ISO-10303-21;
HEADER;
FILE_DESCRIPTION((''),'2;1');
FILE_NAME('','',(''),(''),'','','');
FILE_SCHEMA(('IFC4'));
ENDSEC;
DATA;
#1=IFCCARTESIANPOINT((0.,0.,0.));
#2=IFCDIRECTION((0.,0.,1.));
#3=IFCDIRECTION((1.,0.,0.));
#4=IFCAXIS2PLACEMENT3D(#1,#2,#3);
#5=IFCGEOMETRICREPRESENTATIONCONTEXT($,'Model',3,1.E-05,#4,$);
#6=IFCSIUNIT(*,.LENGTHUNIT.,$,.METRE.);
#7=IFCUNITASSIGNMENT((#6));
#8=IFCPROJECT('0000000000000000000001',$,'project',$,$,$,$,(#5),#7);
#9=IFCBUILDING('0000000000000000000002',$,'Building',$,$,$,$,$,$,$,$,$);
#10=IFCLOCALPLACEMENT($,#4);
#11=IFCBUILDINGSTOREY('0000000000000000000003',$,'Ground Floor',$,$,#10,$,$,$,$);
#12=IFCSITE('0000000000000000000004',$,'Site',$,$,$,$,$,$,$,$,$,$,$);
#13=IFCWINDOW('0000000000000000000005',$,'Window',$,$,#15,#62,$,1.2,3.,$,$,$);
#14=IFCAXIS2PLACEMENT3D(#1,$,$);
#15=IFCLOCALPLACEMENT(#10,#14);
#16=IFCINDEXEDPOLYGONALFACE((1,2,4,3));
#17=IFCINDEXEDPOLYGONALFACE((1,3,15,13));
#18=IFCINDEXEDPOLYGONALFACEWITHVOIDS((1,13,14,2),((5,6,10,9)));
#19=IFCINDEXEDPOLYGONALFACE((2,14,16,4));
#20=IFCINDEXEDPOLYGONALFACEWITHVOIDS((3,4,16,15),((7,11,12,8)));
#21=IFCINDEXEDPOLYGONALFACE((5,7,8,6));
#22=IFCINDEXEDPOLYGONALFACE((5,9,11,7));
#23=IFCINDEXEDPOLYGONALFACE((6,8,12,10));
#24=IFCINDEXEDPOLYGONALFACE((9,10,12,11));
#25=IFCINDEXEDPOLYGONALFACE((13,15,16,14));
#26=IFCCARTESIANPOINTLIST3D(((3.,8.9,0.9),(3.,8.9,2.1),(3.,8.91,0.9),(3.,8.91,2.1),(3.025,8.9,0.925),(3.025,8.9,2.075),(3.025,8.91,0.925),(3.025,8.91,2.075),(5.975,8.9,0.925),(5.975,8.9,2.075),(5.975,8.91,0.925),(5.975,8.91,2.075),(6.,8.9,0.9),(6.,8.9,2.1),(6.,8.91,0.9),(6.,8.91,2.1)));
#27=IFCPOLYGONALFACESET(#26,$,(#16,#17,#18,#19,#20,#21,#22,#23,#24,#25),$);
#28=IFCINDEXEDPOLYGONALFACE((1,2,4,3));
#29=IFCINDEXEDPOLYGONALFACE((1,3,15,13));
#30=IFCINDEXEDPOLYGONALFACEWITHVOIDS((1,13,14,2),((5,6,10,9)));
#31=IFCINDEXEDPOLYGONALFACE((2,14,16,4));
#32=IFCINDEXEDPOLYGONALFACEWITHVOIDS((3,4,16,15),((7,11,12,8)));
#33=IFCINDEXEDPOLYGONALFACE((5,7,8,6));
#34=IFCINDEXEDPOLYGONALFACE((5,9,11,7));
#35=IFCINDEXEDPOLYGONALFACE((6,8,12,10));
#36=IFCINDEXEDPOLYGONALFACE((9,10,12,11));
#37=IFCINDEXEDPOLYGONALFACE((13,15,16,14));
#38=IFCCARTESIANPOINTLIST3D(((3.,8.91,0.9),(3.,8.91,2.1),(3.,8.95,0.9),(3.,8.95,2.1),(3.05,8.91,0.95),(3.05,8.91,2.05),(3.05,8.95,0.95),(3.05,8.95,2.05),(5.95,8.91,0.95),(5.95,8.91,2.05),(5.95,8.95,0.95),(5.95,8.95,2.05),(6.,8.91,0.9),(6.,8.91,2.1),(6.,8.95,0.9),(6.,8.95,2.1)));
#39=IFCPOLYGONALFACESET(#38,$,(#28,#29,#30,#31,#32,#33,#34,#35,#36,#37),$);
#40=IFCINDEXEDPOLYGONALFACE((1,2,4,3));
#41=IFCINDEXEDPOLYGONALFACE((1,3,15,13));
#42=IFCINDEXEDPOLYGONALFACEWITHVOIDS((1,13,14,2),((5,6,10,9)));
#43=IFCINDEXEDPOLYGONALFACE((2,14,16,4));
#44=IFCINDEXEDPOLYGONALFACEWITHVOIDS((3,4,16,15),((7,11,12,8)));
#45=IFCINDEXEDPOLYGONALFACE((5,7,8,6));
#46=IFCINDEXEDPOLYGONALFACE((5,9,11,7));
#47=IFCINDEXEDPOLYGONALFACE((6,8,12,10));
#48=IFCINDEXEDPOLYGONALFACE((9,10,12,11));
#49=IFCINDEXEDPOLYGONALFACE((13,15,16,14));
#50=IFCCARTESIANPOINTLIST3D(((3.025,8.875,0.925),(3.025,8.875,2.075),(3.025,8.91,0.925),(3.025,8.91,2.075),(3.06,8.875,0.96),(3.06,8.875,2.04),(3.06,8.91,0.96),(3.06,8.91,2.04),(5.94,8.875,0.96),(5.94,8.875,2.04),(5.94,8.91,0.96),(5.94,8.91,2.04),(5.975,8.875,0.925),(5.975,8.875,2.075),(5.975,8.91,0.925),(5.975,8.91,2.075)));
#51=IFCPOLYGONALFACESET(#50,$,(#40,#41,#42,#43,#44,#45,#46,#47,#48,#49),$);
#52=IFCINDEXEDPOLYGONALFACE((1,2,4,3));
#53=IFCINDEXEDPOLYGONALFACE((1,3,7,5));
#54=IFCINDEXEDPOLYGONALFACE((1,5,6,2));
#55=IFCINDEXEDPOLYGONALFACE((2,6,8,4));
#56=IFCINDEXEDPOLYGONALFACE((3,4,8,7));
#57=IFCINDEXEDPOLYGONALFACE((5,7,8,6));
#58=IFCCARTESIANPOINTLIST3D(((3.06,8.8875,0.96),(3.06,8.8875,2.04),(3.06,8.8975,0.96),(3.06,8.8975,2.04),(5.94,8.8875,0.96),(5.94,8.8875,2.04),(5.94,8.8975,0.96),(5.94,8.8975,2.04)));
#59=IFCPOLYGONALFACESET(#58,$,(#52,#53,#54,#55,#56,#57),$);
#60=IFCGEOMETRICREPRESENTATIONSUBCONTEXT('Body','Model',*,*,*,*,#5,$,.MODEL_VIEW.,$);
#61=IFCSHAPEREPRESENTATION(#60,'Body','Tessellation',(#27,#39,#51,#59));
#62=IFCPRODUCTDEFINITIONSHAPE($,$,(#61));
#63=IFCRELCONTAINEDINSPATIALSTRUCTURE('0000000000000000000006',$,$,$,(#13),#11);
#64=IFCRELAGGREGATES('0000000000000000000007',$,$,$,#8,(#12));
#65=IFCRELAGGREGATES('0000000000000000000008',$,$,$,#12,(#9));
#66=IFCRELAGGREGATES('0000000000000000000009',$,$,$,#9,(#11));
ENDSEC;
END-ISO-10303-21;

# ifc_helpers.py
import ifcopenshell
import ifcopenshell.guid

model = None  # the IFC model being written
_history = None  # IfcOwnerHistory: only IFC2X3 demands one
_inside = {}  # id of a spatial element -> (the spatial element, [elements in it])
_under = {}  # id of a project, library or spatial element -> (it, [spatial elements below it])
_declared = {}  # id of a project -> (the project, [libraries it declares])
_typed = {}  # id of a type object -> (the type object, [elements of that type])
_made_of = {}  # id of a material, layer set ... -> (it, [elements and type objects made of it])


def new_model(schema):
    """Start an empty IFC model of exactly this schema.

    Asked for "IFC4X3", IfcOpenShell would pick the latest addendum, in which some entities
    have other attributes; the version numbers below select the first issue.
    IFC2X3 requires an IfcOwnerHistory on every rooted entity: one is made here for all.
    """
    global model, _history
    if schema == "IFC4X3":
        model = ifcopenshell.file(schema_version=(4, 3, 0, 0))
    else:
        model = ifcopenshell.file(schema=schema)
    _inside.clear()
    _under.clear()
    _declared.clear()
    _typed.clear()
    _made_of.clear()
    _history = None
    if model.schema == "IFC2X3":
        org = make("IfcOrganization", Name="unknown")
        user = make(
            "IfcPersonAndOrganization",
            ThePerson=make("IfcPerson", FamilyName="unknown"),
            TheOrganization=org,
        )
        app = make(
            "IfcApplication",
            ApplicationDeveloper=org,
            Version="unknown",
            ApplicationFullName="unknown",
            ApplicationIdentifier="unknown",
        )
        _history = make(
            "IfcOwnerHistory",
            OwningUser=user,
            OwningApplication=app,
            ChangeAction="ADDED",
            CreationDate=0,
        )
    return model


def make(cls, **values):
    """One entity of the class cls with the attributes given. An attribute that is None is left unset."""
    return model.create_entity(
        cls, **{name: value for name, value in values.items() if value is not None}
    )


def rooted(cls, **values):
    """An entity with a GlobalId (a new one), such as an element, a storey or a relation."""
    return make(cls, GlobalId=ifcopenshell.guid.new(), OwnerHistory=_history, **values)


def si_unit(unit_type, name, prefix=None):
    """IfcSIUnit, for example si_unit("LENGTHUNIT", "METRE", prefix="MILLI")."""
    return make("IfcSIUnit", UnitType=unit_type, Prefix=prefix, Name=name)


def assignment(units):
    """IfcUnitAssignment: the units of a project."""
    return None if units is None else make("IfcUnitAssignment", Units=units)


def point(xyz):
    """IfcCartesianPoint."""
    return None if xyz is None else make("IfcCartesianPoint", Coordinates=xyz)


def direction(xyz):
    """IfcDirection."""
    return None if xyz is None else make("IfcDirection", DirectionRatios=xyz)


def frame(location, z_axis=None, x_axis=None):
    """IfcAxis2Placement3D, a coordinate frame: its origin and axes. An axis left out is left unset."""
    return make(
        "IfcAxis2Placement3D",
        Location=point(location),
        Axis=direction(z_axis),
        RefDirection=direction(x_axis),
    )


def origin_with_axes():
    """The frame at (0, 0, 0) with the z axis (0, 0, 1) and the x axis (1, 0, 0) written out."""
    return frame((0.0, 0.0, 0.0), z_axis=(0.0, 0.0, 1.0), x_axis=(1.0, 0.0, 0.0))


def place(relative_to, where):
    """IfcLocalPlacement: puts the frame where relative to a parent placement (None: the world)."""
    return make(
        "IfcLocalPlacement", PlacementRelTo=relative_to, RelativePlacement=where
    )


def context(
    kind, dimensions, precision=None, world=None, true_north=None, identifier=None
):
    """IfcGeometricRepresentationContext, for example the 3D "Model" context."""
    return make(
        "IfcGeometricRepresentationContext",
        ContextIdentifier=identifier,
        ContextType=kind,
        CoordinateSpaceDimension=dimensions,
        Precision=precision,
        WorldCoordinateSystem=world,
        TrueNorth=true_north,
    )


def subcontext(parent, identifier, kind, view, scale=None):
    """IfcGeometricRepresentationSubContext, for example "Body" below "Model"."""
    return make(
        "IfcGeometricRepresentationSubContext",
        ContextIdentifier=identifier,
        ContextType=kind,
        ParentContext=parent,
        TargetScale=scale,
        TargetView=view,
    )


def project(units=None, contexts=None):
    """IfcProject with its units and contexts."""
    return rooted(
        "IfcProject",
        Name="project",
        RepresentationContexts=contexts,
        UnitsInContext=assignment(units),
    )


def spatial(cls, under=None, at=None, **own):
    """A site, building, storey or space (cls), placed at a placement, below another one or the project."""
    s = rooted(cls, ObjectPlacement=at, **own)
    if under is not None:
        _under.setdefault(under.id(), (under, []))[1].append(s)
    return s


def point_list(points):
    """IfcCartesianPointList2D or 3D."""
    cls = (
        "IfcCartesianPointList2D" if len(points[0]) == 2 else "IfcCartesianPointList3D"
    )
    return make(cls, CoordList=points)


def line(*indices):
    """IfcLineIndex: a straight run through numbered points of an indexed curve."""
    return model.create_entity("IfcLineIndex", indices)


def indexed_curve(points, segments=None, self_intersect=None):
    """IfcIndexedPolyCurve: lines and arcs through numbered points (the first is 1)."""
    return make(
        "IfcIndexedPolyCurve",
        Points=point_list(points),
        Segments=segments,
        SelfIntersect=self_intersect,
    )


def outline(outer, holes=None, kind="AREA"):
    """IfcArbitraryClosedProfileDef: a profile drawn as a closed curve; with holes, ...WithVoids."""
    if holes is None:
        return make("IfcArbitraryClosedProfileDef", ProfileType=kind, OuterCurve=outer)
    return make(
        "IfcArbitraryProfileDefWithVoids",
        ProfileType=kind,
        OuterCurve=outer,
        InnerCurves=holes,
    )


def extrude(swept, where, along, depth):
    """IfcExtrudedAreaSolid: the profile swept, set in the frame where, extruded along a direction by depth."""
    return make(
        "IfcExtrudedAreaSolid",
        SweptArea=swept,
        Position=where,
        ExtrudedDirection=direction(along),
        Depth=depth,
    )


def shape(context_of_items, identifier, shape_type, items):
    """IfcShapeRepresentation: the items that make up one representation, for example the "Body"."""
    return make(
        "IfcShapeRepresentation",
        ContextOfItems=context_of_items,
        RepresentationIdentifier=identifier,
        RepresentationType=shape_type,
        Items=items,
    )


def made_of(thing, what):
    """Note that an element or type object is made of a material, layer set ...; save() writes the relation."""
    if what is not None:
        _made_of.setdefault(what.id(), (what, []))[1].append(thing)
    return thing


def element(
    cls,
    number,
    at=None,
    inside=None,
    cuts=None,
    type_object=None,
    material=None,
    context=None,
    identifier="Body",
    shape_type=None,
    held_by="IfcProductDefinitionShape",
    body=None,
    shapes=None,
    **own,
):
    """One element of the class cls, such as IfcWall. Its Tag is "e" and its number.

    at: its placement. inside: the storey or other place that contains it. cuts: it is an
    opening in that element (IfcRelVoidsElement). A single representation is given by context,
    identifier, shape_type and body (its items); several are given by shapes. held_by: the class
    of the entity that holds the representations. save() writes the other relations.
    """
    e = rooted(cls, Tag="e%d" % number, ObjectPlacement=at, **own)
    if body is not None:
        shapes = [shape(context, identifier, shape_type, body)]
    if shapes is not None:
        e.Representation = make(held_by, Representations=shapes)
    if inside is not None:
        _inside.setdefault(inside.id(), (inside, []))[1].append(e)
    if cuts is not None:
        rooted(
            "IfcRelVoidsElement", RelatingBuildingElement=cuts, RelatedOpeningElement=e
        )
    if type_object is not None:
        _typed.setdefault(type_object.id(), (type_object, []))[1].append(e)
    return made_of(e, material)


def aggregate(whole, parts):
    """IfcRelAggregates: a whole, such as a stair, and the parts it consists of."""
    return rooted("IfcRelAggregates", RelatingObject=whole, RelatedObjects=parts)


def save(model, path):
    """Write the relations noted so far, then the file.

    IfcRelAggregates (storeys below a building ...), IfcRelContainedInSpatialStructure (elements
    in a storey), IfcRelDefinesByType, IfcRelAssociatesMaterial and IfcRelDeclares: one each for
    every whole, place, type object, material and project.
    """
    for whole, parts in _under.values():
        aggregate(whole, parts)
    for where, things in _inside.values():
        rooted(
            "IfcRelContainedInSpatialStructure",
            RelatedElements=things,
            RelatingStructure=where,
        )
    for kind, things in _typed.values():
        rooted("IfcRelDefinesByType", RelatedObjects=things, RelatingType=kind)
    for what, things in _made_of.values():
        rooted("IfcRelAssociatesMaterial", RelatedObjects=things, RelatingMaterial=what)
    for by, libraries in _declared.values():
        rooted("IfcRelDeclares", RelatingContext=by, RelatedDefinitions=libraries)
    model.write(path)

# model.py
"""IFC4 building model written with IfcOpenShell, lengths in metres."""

from ifc_helpers import new_model, si_unit, frame, origin_with_axes, place, context, subcontext, project, spatial, line, indexed_curve, outline, extrude, element, save


model = new_model("IFC4")

# Units and contexts
model_context = context("Model", 3, precision=1e-05, world=origin_with_axes())
body_context = subcontext(model_context, "Body", "Model", "MODEL_VIEW")
ifc_project = project(units=[si_unit("LENGTHUNIT", "METRE")], contexts=[model_context])

# Site, building, storey
site = spatial("IfcSite", under=ifc_project, Name="Site")
building = spatial("IfcBuilding", under=site, Name="Building")
storey_placement = place(None, origin_with_axes())
storey = spatial("IfcBuildingStorey", under=building, at=storey_placement, Name="Ground Floor")

# Window
window_1_placement = place(storey_placement, frame((6.0, 9.0, 0.9), z_axis=(0.0, 0.0, 1.0), x_axis=(-1.0, 0.0, 0.0)))
element("IfcWindow", 1, at=window_1_placement, inside=storey, Name="Window", OverallHeight=1.2, OverallWidth=3.0, context=body_context, shape_type="SweptSolid", body=[
    extrude(outline(indexed_curve([(0.0, 0.0), (3.0, 0.0), (3.0, 1.2), (0.0, 1.2)], segments=[line(1, 2, 3, 4, 1)]), holes=[indexed_curve([(0.025, 0.025), (2.975, 0.025), (2.975, 1.175), (0.025, 1.175)], segments=[line(1, 2, 3, 4, 1)])]), frame((0.0, 0.09, 0.0), z_axis=(0.0, -1.0, 0.0), x_axis=(1.0, 0.0, 0.0)), (0.0, 0.0, -1.0), 0.01),
    extrude(outline(indexed_curve([(0.0, 0.0), (3.0, 0.0), (3.0, 1.2), (0.0, 1.2)], segments=[line(1, 2, 3, 4, 1)]), holes=[indexed_curve([(0.05, 0.05), (2.95, 0.05), (2.95, 1.15), (0.05, 1.15)], segments=[line(1, 2, 3, 4, 1)])]), frame((0.0, 0.05, 0.0), z_axis=(0.0, -1.0, 0.0), x_axis=(1.0, 0.0, 0.0)), (0.0, 0.0, -1.0), 0.04),
    extrude(outline(indexed_curve([(0.0, 0.0), (2.95, 0.0), (2.95, 1.15), (0.0, 1.15)], segments=[line(1, 2, 3, 4, 1)]), holes=[indexed_curve([(0.035, 0.035), (2.915, 0.035), (2.915, 1.115), (0.035, 1.115)], segments=[line(1, 2, 3, 4, 1)])]), frame((0.025, 0.09, 0.025), z_axis=(0.0, -1.0, 0.0), x_axis=(1.0, 0.0, 0.0)), (0.0, 0.0, -1.0), 0.035),
    extrude(outline(indexed_curve([(0.035, 0.035), (2.915, 0.035), (2.915, 1.115), (0.035, 1.115)], segments=[line(1, 2, 3, 4, 1)])), frame((0.025, 0.1025, 0.025), z_axis=(0.0, -1.0, 0.0), x_axis=(1.0, 0.0, 0.0)), (0.0, 0.0, -1.0), 0.01),
])

save(model, "model.ifc")
